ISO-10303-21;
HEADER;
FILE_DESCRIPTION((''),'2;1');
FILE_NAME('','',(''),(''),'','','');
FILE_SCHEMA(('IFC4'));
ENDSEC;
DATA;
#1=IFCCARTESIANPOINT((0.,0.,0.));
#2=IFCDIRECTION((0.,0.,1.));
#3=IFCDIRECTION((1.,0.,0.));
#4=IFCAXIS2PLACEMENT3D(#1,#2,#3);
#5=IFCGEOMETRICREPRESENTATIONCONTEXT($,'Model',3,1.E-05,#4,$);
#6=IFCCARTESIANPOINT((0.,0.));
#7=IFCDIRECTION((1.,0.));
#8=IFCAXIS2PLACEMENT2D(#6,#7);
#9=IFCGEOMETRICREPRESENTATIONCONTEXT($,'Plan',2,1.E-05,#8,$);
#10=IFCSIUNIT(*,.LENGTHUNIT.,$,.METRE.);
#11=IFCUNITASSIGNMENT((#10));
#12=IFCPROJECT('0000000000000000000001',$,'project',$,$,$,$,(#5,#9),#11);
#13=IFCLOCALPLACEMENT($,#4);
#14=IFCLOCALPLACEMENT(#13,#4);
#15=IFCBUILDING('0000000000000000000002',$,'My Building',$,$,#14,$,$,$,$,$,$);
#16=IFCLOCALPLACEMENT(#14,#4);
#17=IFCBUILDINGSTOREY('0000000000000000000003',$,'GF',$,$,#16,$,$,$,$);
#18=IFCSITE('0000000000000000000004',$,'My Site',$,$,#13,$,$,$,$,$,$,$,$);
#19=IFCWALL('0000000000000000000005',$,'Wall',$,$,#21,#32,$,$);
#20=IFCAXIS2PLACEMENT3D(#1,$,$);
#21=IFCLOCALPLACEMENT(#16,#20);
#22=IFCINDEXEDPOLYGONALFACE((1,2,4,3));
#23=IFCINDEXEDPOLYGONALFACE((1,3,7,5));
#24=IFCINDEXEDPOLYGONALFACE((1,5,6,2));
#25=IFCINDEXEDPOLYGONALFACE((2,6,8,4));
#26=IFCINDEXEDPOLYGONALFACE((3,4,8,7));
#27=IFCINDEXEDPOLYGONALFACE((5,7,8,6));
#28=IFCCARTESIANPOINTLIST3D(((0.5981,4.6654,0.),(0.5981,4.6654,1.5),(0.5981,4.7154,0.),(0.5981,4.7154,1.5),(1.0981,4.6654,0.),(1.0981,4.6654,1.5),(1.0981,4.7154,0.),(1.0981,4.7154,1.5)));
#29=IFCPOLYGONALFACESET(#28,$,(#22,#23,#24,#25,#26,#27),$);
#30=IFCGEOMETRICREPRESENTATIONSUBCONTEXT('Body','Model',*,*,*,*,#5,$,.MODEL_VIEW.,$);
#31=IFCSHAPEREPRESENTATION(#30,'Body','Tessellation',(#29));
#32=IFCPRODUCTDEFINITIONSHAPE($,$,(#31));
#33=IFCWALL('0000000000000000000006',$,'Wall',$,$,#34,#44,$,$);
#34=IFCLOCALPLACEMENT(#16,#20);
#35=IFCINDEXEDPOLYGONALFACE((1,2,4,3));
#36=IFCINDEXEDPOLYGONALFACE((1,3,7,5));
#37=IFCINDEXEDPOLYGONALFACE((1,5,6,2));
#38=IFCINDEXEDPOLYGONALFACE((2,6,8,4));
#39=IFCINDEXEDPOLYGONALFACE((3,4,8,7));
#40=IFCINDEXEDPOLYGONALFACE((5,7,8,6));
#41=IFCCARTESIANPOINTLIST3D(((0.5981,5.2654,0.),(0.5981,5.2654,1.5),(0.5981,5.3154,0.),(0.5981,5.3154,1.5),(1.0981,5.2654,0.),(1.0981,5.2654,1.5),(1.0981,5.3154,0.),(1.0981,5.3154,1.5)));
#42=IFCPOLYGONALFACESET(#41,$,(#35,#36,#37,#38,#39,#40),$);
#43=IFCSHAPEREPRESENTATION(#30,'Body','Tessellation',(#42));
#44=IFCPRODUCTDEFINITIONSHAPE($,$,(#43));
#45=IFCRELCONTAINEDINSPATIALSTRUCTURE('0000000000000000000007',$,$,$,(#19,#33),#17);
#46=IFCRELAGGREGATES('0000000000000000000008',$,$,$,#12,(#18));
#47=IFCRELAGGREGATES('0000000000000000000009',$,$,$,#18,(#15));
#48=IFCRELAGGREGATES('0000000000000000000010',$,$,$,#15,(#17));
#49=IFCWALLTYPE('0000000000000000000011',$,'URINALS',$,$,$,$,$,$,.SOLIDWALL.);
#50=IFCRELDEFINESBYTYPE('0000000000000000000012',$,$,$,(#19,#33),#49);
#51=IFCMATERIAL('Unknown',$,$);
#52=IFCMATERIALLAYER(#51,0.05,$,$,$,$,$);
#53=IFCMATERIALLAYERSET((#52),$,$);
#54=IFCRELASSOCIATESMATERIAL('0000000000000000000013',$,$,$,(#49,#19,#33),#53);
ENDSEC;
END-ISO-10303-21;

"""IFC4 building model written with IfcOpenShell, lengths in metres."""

from ifc_helpers import new_model, si_unit, frame, origin_with_axes, origin_2d_with_axis, place, context, subcontext, project, spatial, line, indexed_curve, outline, extrude, material, layer, layer_set, layer_usage, type_object, element, save


model = new_model("IFC4")

# Units and contexts
model_context = context("Model", 3, precision=1e-05, world=origin_with_axes())
plan_context = context("Plan", 2, precision=1e-05, world=origin_2d_with_axis())
body_context_1 = subcontext(model_context, "Body", "Model", "MODEL_VIEW")
ifc_project = project(units=[si_unit("LENGTHUNIT", "METRE")], contexts=[model_context, plan_context])

# Site, building, storey
site_placement = place(None, origin_with_axes())
site = spatial("IfcSite", under=ifc_project, at=site_placement, Name="My Site")
building_placement = place(site_placement, origin_with_axes())
building = spatial("IfcBuilding", under=site, at=building_placement, Name="My Building")
storey_placement = place(building_placement, origin_with_axes())
storey = spatial("IfcBuildingStorey", under=building, at=storey_placement, Name="GF")

# Shared definitions
ifc_material = material(Name="Unknown")

# Walls
ifc_layer_1 = layer(ifc_material, 0.05)
ifc_layer_set_1 = layer_set([ifc_layer_1])
wall_type_1 = type_object("IfcWallType", Name="URINALS", PredefinedType="SOLIDWALL", material=ifc_layer_set_1)
ifc_layer_usage_1 = layer_usage(ifc_layer_set_1, "AXIS2", "POSITIVE", 0.0)
wall_1_placement = place(storey_placement, frame((0.5981, 4.6654, 0.0), z_axis=(0.0, 0.0, 1.0), x_axis=(1.0, 0.0, 0.0)))
element("IfcWall", 1, at=wall_1_placement, inside=storey, type_object=wall_type_1, material=ifc_layer_usage_1, Name="Wall", context=body_context_1, shape_type="SweptSolid", body=[
    extrude(outline(indexed_curve([(0.0, 0.0), (0.0, 0.05), (0.5, 0.05), (0.5, 0.0)], segments=[line(1, 2, 3, 4, 1)])), origin_with_axes(), (0.0, 0.0, 1.0), 1.5),
])
ifc_layer_usage_2 = layer_usage(ifc_layer_set_1, "AXIS2", "POSITIVE", 0.0)
wall_2_placement = place(storey_placement, frame((0.5981, 5.2654, 0.0), z_axis=(0.0, 0.0, 1.0), x_axis=(1.0, 0.0, 0.0)))
element("IfcWall", 2, at=wall_2_placement, inside=storey, type_object=wall_type_1, material=ifc_layer_usage_2, Name="Wall", context=body_context_1, shape_type="SweptSolid", body=[
    extrude(outline(indexed_curve([(0.0, 0.0), (0.0, 0.05), (0.5, 0.05), (0.5, 0.0)], segments=[line(1, 2, 3, 4, 1)])), origin_with_axes(), (0.0, 0.0, 1.0), 1.5),
])

save(model, "model.ifc")
